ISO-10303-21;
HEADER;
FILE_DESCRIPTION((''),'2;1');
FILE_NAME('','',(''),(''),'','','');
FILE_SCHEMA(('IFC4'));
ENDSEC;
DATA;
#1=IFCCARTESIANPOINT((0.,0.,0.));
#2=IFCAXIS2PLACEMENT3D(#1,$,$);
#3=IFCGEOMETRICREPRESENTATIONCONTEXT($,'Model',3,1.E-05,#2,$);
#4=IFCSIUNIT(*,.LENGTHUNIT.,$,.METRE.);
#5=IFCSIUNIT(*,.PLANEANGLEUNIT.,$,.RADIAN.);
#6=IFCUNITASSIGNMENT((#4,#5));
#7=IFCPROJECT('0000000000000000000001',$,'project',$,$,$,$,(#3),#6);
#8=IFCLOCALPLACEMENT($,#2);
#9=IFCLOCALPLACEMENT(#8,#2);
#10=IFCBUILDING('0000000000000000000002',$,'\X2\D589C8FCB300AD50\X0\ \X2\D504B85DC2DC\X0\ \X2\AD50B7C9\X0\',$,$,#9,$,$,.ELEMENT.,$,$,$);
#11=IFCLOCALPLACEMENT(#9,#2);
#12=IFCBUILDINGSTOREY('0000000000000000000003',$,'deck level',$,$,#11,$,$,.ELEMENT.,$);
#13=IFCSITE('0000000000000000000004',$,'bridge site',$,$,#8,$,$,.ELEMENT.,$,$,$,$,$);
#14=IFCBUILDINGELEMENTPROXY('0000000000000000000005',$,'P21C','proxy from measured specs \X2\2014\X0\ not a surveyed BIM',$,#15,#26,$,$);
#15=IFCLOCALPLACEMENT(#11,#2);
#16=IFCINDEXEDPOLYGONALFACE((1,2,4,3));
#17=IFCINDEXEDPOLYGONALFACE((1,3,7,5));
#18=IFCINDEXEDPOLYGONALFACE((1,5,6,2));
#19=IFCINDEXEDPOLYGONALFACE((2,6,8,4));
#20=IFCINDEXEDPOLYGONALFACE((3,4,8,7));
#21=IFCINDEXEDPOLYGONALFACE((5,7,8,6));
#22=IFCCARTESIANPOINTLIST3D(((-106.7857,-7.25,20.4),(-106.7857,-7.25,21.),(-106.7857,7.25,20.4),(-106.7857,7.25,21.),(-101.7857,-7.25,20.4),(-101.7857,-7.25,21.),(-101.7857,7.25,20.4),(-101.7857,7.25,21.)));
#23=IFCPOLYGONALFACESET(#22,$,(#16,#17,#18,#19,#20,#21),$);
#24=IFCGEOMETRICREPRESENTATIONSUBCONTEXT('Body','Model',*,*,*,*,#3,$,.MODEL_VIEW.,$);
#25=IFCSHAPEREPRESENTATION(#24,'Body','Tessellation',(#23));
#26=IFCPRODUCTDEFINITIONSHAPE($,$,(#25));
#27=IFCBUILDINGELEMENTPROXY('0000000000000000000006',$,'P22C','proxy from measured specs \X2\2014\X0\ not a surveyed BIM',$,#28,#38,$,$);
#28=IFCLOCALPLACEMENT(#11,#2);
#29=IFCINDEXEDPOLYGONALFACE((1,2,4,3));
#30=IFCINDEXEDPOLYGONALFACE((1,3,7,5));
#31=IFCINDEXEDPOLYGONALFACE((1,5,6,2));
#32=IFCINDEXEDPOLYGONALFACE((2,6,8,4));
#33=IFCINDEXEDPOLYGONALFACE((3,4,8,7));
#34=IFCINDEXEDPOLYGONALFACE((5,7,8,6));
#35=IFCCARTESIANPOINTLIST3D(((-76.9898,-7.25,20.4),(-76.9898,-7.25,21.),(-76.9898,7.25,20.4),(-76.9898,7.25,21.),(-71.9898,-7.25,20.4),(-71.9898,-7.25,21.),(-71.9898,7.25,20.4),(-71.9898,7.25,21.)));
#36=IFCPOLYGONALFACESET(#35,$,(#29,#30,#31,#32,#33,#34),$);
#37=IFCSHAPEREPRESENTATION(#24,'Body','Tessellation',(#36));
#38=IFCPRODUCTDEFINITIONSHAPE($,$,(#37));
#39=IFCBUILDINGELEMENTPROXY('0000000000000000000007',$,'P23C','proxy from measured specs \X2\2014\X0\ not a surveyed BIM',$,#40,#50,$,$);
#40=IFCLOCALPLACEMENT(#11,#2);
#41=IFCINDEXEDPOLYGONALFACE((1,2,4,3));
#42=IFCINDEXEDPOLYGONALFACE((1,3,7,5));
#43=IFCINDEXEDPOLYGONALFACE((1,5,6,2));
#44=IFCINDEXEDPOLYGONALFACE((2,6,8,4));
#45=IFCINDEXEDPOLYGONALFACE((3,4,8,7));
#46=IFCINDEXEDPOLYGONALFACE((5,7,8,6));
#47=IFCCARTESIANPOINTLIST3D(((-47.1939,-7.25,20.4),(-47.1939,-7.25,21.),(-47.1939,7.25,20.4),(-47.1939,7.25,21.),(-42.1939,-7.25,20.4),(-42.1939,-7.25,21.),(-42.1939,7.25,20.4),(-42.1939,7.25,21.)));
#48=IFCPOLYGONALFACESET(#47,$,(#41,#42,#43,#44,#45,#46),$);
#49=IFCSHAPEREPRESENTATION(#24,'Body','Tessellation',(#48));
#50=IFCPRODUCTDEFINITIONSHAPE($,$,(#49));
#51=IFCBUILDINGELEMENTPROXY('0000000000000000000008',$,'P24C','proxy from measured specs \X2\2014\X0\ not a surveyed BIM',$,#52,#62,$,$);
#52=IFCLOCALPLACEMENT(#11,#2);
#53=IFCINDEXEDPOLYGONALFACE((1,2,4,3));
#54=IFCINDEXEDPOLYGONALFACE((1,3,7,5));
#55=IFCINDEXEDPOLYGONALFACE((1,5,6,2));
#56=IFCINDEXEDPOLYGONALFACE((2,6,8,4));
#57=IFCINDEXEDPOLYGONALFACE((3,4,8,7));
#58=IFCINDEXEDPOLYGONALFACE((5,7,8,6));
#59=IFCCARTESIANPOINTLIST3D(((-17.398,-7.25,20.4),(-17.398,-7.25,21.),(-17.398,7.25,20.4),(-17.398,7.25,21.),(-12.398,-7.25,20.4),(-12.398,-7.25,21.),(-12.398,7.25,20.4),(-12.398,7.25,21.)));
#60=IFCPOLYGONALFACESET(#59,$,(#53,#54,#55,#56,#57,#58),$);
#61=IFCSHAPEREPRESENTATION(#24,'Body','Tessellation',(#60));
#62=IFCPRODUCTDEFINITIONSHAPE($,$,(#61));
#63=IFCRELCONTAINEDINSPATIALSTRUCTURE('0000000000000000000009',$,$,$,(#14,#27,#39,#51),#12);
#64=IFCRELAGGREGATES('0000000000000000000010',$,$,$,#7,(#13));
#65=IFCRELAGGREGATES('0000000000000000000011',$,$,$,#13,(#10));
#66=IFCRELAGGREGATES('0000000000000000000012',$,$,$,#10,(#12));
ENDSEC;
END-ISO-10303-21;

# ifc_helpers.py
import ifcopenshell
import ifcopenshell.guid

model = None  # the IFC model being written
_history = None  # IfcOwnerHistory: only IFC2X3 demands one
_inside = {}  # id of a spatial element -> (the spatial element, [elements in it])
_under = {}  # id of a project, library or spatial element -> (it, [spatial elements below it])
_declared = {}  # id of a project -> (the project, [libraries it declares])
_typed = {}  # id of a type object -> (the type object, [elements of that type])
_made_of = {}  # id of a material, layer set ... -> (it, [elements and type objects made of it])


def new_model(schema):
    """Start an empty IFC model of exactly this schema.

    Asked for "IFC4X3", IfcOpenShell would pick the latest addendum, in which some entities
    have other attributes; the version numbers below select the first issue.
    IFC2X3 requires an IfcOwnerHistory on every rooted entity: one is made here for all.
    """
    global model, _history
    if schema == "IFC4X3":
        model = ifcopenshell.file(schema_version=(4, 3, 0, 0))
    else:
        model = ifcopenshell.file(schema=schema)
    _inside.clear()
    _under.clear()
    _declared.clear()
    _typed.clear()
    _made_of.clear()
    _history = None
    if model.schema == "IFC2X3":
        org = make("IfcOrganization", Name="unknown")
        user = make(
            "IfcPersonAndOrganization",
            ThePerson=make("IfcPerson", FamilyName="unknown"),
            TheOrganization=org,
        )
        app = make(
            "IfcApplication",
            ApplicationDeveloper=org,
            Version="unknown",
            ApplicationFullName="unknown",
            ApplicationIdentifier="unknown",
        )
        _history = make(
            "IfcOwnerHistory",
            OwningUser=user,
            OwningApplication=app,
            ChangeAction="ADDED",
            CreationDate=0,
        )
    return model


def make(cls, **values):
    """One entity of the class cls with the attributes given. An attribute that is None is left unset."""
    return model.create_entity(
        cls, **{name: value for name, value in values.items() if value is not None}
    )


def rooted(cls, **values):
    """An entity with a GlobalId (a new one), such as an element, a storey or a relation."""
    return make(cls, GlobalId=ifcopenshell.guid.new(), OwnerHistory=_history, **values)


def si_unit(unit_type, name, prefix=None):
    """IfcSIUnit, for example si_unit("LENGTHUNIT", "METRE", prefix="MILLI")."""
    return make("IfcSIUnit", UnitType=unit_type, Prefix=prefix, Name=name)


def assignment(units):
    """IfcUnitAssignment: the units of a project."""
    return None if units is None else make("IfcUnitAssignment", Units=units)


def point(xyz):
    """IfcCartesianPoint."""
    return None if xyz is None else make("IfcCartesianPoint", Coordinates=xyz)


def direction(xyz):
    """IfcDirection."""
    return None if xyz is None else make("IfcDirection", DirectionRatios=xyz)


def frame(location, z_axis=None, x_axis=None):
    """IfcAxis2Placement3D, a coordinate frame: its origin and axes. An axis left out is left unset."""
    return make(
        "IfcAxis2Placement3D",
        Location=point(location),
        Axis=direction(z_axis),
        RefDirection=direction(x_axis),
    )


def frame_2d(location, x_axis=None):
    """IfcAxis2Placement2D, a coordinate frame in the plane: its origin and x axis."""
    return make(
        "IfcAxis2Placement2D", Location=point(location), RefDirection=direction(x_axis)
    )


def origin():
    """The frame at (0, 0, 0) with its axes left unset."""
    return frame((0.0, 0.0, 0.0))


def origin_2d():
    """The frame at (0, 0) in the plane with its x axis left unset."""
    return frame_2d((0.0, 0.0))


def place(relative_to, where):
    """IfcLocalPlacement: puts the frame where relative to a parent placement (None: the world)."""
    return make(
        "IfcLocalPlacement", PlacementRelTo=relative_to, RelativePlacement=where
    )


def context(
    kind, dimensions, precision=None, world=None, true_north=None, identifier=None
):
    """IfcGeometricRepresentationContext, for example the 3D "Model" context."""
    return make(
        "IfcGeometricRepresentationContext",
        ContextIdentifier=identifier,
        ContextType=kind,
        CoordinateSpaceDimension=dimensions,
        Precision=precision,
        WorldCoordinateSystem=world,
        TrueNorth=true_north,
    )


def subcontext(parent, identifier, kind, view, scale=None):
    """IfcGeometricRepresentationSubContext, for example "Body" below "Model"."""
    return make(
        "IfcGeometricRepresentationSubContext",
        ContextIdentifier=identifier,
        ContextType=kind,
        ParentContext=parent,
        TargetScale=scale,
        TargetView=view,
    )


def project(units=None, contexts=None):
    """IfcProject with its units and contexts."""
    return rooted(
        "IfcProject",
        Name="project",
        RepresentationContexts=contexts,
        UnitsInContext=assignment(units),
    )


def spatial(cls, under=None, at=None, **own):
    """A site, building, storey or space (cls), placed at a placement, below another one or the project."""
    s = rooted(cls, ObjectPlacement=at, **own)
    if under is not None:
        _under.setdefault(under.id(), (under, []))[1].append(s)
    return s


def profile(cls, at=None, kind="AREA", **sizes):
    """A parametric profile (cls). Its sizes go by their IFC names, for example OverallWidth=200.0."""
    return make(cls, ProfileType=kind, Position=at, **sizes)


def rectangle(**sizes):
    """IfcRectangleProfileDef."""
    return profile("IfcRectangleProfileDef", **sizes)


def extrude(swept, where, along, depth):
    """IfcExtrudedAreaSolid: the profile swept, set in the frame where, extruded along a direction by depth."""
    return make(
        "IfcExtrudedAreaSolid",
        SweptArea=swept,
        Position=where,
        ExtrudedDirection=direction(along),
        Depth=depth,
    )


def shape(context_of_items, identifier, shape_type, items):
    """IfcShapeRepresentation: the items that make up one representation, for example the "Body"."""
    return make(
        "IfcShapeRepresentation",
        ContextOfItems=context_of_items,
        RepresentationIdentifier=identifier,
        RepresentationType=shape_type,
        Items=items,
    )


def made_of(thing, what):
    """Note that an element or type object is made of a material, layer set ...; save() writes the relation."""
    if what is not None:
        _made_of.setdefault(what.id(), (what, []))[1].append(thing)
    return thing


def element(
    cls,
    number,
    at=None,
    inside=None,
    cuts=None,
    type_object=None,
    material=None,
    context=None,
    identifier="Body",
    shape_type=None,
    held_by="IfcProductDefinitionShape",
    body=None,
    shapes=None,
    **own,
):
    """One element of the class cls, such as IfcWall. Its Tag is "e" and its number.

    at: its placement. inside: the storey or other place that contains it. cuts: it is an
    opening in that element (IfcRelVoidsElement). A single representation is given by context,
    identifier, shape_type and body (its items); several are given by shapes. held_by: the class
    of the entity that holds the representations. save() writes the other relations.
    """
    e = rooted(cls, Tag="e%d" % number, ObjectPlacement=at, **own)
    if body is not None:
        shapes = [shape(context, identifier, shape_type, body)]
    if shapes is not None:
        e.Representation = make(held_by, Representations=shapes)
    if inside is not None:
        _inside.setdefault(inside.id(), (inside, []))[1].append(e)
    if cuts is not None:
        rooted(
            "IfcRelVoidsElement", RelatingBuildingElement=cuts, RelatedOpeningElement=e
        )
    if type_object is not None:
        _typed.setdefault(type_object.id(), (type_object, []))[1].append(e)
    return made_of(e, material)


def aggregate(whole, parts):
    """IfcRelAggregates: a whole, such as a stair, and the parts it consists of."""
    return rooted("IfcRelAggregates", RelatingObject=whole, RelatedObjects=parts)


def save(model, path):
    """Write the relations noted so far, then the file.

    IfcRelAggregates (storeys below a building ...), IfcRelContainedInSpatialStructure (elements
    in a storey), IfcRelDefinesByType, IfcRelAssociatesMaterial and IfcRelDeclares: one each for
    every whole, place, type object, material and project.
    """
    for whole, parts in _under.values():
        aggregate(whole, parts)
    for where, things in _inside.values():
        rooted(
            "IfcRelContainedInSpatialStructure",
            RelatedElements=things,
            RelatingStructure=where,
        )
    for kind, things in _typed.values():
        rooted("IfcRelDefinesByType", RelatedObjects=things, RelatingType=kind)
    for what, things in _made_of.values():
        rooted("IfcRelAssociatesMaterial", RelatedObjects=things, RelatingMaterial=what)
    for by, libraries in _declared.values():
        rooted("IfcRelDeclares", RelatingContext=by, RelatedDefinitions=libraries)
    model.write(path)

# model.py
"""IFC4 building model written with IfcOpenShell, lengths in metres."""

from ifc_helpers import new_model, si_unit, frame, origin, origin_2d, place, context, subcontext, project, spatial, rectangle, extrude, element, save


model = new_model("IFC4")

# Units and contexts
model_context = context("Model", 3, precision=1e-05, world=origin())
body_context = subcontext(model_context, "Body", "Model", "MODEL_VIEW")
ifc_project = project(units=[si_unit("LENGTHUNIT", "METRE"), si_unit("PLANEANGLEUNIT", "RADIAN")], contexts=[model_context])

# Site, building, storey
site_placement = place(None, origin())
site = spatial("IfcSite", under=ifc_project, at=site_placement, Name="bridge site", CompositionType="ELEMENT")
building_placement = place(site_placement, origin())
building = spatial("IfcBuilding", under=site, at=building_placement, Name="행주대교 프록시 교량", CompositionType="ELEMENT")
storey_placement = place(building_placement, origin())
storey = spatial("IfcBuildingStorey", under=building, at=storey_placement, Name="deck level", CompositionType="ELEMENT")

# Building element proxies
for number, where, name in (
    (1, (-104.2857, 0.0, 20.4), "P21C"),
    (2, (-74.4898, 0.0, 20.4), "P22C"),
    (3, (-44.6939, 0.0, 20.4), "P23C"),
    (4, (-14.898, 0.0, 20.4), "P24C"),
):
    element("IfcBuildingElementProxy", number, at=place(storey_placement, frame(where)), inside=storey, Name=name, Description="proxy from measured specs — not a surveyed BIM", context=body_context, shape_type="SweptSolid", body=[
        extrude(rectangle(XDim=5.0, YDim=14.5, at=origin_2d()), origin(), (0.0, 0.0, 1.0), 0.6),
    ])

save(model, "model.ifc")
